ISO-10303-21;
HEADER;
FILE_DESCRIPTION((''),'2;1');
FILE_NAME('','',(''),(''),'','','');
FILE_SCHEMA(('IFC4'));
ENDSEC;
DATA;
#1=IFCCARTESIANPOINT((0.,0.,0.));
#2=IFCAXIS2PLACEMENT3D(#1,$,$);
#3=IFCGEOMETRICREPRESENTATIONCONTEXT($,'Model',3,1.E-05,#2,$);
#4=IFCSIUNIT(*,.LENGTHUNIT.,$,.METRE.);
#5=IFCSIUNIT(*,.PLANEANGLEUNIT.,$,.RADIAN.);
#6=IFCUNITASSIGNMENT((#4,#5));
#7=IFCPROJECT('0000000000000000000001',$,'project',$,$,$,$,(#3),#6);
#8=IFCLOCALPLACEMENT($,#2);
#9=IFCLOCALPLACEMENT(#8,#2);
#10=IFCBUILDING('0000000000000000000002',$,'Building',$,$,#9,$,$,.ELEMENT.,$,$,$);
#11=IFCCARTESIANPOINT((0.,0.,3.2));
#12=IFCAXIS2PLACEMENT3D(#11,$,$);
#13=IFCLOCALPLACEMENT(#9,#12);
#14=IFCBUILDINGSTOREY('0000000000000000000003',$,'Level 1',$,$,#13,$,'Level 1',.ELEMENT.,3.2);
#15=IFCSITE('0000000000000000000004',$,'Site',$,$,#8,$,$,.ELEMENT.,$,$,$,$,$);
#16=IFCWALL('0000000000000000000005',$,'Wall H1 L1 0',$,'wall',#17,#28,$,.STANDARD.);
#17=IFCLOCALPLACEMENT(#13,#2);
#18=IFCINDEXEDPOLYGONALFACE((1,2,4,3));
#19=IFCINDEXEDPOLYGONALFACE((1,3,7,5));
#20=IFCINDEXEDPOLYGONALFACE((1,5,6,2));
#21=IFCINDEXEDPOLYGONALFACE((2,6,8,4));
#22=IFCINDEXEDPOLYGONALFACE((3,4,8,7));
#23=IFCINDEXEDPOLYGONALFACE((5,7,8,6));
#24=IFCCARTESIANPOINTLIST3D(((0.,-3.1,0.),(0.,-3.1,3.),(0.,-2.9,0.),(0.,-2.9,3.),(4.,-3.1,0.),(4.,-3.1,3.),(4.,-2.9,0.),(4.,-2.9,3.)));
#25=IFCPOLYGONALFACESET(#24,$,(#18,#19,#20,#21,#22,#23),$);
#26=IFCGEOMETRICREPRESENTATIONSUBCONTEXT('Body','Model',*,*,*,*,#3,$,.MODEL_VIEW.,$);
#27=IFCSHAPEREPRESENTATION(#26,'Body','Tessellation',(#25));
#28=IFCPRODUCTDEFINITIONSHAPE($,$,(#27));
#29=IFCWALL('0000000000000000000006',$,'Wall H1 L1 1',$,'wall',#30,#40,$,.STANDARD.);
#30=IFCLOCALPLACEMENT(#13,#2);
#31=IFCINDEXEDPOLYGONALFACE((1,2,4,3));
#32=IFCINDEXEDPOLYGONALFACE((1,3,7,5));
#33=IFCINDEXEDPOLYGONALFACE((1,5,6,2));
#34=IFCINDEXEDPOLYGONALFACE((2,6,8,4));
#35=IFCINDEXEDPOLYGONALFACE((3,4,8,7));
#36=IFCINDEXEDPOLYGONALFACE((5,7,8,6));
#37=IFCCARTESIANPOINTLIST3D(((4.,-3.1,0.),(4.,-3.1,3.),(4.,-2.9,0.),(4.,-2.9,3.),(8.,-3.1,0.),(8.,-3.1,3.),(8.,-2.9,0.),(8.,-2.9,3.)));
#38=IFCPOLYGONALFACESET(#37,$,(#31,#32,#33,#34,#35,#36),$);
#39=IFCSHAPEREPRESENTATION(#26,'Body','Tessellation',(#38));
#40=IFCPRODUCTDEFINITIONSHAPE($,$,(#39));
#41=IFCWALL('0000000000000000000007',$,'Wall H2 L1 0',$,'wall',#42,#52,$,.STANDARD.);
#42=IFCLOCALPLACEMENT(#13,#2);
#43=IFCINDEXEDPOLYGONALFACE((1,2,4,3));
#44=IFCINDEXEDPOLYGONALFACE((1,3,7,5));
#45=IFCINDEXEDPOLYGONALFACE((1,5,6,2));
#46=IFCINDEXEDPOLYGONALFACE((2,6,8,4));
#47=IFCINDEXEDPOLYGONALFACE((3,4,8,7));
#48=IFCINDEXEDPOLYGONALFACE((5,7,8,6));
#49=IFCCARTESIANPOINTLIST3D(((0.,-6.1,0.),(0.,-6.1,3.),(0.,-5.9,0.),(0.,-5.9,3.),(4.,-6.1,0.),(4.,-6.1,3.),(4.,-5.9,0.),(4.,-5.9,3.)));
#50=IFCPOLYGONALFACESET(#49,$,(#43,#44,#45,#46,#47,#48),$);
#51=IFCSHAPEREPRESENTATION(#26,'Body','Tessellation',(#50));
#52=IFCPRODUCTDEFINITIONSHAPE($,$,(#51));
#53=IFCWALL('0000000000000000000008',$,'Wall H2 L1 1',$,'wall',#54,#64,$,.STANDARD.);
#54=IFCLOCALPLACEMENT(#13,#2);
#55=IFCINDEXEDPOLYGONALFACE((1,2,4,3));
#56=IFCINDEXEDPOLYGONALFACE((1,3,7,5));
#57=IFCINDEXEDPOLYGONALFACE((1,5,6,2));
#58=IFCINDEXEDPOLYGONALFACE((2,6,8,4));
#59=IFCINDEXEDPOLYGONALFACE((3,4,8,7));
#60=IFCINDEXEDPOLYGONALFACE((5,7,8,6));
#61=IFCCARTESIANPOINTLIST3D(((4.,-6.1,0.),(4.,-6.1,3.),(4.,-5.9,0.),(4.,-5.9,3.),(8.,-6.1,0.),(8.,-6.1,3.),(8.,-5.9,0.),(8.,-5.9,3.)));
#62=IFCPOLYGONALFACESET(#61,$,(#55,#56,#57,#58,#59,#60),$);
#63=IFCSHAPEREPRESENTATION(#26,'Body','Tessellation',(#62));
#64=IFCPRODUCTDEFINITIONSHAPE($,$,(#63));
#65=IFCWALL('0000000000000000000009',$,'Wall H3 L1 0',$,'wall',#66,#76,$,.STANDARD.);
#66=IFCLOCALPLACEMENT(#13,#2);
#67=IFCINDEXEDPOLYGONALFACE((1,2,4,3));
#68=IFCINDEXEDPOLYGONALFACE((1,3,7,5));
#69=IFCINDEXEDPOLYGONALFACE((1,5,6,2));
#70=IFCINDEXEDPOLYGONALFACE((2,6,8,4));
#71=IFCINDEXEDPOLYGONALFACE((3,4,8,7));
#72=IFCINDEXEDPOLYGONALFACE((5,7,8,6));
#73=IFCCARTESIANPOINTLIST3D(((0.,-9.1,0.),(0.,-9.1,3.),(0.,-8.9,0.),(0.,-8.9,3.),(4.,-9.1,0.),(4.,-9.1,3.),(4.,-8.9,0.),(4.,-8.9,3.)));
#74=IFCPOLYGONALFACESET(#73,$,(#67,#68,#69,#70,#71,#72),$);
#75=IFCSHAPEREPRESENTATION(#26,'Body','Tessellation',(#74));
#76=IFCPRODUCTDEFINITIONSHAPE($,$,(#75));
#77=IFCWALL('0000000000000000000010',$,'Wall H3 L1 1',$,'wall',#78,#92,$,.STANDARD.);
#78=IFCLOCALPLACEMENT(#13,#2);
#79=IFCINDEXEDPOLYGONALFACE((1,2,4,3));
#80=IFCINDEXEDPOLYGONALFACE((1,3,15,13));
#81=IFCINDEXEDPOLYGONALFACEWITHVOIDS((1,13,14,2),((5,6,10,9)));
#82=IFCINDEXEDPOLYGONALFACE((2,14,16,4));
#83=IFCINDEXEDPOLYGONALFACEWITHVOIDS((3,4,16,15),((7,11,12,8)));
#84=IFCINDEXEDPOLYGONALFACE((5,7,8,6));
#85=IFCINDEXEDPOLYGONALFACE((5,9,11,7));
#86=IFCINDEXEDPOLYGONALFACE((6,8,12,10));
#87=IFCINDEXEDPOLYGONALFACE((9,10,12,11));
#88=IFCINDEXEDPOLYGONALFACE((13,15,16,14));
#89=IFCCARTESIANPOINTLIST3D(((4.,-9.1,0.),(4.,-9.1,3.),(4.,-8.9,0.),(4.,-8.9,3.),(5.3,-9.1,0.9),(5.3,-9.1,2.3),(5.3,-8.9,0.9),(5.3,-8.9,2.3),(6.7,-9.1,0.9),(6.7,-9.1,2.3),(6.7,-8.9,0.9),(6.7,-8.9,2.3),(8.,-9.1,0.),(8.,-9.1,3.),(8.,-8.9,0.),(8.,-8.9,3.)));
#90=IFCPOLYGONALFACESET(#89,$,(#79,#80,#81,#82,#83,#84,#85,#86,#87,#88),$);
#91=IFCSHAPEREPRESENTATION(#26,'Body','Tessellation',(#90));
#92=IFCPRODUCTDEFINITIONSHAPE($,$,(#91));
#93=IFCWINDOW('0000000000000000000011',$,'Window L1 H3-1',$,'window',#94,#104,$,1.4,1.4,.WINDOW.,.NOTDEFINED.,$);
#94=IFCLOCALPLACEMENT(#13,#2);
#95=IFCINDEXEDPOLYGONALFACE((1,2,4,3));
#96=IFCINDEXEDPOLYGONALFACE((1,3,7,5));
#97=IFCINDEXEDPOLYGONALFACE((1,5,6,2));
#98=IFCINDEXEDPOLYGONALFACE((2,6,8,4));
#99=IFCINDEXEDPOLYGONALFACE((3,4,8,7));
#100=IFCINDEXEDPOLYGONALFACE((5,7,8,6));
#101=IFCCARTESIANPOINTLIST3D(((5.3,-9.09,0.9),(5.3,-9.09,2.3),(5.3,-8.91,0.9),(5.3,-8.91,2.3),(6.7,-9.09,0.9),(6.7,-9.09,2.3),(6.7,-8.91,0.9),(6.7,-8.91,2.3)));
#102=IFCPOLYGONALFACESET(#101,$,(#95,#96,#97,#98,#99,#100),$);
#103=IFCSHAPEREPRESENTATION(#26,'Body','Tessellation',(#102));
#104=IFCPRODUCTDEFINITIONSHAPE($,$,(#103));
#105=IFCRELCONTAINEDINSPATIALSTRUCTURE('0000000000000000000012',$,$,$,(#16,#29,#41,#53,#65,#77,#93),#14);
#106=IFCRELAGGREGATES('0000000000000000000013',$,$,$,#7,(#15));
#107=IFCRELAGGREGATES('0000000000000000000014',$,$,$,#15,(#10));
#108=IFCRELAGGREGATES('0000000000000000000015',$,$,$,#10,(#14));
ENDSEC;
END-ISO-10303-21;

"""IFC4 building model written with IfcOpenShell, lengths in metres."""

from ifc_helpers import new_model, si_unit, frame, frame_2d, origin, origin_2d, place, context, subcontext, project, spatial, rectangle, extrude, element, fill, save


model = new_model("IFC4")

# Units and contexts
model_context = context("Model", 3, precision=1e-05, world=origin())
body_context = subcontext(model_context, "Body", "Model", "MODEL_VIEW")
ifc_project = project(units=[si_unit("LENGTHUNIT", "METRE"), si_unit("PLANEANGLEUNIT", "RADIAN")], contexts=[model_context])

# Site, building, storey
site_placement = place(None, origin())
site = spatial("IfcSite", under=ifc_project, at=site_placement, Name="Site", CompositionType="ELEMENT")
building_placement = place(site_placement, origin())
building = spatial("IfcBuilding", under=site, at=building_placement, Name="Building", CompositionType="ELEMENT")
storey_placement = place(building_placement, frame((0.0, 0.0, 3.2)))
storey = spatial("IfcBuildingStorey", under=building, at=storey_placement, Name="Level 1", LongName="Level 1", CompositionType="ELEMENT", Elevation=3.2)

# Walls
for number, where, z_axis, x_axis, name in (
    (1, (0.0, -3.0, 0.0), (0.0, 0.0, 1.0), (1.0, 0.0, 0.0), "Wall H1 L1 0"),
    (2, (4.0, -3.0, 0.0), (0.0, 0.0, 1.0), (1.0, 0.0, 0.0), "Wall H1 L1 1"),
    (3, (0.0, -6.0, 0.0), (0.0, 0.0, 1.0), (1.0, 0.0, 0.0), "Wall H2 L1 0"),
    (4, (4.0, -6.0, 0.0), (0.0, 0.0, 1.0), (1.0, 0.0, 0.0), "Wall H2 L1 1"),
    (5, (0.0, -9.0, 0.0), (0.0, 0.0, 1.0), (1.0, 0.0, 0.0), "Wall H3 L1 0"),
):
    element("IfcWall", number, at=place(storey_placement, frame(where, z_axis=z_axis, x_axis=x_axis)), inside=storey, Name=name, ObjectType="wall", PredefinedType="STANDARD", context=body_context, shape_type="SweptSolid", body=[
        extrude(rectangle(XDim=4.0, YDim=0.2, at=frame_2d((2.0, 0.0))), origin(), (0.0, 0.0, 1.0), 3.0),
    ])

# Wall, opening, window
wall_1_placement = place(storey_placement, frame((4.0, -9.0, 0.0), z_axis=(0.0, 0.0, 1.0), x_axis=(1.0, 0.0, 0.0)))
wall_1 = element("IfcWall", 6, at=wall_1_placement, inside=storey, Name="Wall H3 L1 1", ObjectType="wall", PredefinedType="STANDARD", context=body_context, shape_type="SweptSolid", body=[
    extrude(rectangle(XDim=4.0, YDim=0.2, at=frame_2d((2.0, 0.0))), origin(), (0.0, 0.0, 1.0), 3.0),
])
opening_1_placement = place(storey_placement, frame((6.0, -9.0, 0.9), z_axis=(0.0, 0.0, 1.0), x_axis=(1.0, 0.0, 0.0)))
opening_1 = element("IfcOpeningElement", 7, at=opening_1_placement, cuts=wall_1, ObjectType="Opening", PredefinedType="OPENING", context=body_context, shape_type="SweptSolid", body=[
    extrude(rectangle(XDim=1.4, YDim=0.22, at=origin_2d()), origin(), (0.0, 0.0, 1.0), 1.4),
])
window_1_placement = place(storey_placement, frame((6.0, -9.0, 0.9), z_axis=(0.0, 0.0, 1.0), x_axis=(1.0, 0.0, 0.0)))
window_1 = element("IfcWindow", 8, at=window_1_placement, inside=storey, Name="Window L1 H3-1", ObjectType="window", OverallHeight=1.4, OverallWidth=1.4, PartitioningType="NOTDEFINED", PredefinedType="WINDOW", context=body_context, shape_type="SweptSolid", body=[
    extrude(rectangle(XDim=1.4, YDim=0.18, at=origin_2d()), origin(), (0.0, 0.0, 1.0), 1.4),
])
fill(opening_1, window_1)

save(model, "model.ifc")
